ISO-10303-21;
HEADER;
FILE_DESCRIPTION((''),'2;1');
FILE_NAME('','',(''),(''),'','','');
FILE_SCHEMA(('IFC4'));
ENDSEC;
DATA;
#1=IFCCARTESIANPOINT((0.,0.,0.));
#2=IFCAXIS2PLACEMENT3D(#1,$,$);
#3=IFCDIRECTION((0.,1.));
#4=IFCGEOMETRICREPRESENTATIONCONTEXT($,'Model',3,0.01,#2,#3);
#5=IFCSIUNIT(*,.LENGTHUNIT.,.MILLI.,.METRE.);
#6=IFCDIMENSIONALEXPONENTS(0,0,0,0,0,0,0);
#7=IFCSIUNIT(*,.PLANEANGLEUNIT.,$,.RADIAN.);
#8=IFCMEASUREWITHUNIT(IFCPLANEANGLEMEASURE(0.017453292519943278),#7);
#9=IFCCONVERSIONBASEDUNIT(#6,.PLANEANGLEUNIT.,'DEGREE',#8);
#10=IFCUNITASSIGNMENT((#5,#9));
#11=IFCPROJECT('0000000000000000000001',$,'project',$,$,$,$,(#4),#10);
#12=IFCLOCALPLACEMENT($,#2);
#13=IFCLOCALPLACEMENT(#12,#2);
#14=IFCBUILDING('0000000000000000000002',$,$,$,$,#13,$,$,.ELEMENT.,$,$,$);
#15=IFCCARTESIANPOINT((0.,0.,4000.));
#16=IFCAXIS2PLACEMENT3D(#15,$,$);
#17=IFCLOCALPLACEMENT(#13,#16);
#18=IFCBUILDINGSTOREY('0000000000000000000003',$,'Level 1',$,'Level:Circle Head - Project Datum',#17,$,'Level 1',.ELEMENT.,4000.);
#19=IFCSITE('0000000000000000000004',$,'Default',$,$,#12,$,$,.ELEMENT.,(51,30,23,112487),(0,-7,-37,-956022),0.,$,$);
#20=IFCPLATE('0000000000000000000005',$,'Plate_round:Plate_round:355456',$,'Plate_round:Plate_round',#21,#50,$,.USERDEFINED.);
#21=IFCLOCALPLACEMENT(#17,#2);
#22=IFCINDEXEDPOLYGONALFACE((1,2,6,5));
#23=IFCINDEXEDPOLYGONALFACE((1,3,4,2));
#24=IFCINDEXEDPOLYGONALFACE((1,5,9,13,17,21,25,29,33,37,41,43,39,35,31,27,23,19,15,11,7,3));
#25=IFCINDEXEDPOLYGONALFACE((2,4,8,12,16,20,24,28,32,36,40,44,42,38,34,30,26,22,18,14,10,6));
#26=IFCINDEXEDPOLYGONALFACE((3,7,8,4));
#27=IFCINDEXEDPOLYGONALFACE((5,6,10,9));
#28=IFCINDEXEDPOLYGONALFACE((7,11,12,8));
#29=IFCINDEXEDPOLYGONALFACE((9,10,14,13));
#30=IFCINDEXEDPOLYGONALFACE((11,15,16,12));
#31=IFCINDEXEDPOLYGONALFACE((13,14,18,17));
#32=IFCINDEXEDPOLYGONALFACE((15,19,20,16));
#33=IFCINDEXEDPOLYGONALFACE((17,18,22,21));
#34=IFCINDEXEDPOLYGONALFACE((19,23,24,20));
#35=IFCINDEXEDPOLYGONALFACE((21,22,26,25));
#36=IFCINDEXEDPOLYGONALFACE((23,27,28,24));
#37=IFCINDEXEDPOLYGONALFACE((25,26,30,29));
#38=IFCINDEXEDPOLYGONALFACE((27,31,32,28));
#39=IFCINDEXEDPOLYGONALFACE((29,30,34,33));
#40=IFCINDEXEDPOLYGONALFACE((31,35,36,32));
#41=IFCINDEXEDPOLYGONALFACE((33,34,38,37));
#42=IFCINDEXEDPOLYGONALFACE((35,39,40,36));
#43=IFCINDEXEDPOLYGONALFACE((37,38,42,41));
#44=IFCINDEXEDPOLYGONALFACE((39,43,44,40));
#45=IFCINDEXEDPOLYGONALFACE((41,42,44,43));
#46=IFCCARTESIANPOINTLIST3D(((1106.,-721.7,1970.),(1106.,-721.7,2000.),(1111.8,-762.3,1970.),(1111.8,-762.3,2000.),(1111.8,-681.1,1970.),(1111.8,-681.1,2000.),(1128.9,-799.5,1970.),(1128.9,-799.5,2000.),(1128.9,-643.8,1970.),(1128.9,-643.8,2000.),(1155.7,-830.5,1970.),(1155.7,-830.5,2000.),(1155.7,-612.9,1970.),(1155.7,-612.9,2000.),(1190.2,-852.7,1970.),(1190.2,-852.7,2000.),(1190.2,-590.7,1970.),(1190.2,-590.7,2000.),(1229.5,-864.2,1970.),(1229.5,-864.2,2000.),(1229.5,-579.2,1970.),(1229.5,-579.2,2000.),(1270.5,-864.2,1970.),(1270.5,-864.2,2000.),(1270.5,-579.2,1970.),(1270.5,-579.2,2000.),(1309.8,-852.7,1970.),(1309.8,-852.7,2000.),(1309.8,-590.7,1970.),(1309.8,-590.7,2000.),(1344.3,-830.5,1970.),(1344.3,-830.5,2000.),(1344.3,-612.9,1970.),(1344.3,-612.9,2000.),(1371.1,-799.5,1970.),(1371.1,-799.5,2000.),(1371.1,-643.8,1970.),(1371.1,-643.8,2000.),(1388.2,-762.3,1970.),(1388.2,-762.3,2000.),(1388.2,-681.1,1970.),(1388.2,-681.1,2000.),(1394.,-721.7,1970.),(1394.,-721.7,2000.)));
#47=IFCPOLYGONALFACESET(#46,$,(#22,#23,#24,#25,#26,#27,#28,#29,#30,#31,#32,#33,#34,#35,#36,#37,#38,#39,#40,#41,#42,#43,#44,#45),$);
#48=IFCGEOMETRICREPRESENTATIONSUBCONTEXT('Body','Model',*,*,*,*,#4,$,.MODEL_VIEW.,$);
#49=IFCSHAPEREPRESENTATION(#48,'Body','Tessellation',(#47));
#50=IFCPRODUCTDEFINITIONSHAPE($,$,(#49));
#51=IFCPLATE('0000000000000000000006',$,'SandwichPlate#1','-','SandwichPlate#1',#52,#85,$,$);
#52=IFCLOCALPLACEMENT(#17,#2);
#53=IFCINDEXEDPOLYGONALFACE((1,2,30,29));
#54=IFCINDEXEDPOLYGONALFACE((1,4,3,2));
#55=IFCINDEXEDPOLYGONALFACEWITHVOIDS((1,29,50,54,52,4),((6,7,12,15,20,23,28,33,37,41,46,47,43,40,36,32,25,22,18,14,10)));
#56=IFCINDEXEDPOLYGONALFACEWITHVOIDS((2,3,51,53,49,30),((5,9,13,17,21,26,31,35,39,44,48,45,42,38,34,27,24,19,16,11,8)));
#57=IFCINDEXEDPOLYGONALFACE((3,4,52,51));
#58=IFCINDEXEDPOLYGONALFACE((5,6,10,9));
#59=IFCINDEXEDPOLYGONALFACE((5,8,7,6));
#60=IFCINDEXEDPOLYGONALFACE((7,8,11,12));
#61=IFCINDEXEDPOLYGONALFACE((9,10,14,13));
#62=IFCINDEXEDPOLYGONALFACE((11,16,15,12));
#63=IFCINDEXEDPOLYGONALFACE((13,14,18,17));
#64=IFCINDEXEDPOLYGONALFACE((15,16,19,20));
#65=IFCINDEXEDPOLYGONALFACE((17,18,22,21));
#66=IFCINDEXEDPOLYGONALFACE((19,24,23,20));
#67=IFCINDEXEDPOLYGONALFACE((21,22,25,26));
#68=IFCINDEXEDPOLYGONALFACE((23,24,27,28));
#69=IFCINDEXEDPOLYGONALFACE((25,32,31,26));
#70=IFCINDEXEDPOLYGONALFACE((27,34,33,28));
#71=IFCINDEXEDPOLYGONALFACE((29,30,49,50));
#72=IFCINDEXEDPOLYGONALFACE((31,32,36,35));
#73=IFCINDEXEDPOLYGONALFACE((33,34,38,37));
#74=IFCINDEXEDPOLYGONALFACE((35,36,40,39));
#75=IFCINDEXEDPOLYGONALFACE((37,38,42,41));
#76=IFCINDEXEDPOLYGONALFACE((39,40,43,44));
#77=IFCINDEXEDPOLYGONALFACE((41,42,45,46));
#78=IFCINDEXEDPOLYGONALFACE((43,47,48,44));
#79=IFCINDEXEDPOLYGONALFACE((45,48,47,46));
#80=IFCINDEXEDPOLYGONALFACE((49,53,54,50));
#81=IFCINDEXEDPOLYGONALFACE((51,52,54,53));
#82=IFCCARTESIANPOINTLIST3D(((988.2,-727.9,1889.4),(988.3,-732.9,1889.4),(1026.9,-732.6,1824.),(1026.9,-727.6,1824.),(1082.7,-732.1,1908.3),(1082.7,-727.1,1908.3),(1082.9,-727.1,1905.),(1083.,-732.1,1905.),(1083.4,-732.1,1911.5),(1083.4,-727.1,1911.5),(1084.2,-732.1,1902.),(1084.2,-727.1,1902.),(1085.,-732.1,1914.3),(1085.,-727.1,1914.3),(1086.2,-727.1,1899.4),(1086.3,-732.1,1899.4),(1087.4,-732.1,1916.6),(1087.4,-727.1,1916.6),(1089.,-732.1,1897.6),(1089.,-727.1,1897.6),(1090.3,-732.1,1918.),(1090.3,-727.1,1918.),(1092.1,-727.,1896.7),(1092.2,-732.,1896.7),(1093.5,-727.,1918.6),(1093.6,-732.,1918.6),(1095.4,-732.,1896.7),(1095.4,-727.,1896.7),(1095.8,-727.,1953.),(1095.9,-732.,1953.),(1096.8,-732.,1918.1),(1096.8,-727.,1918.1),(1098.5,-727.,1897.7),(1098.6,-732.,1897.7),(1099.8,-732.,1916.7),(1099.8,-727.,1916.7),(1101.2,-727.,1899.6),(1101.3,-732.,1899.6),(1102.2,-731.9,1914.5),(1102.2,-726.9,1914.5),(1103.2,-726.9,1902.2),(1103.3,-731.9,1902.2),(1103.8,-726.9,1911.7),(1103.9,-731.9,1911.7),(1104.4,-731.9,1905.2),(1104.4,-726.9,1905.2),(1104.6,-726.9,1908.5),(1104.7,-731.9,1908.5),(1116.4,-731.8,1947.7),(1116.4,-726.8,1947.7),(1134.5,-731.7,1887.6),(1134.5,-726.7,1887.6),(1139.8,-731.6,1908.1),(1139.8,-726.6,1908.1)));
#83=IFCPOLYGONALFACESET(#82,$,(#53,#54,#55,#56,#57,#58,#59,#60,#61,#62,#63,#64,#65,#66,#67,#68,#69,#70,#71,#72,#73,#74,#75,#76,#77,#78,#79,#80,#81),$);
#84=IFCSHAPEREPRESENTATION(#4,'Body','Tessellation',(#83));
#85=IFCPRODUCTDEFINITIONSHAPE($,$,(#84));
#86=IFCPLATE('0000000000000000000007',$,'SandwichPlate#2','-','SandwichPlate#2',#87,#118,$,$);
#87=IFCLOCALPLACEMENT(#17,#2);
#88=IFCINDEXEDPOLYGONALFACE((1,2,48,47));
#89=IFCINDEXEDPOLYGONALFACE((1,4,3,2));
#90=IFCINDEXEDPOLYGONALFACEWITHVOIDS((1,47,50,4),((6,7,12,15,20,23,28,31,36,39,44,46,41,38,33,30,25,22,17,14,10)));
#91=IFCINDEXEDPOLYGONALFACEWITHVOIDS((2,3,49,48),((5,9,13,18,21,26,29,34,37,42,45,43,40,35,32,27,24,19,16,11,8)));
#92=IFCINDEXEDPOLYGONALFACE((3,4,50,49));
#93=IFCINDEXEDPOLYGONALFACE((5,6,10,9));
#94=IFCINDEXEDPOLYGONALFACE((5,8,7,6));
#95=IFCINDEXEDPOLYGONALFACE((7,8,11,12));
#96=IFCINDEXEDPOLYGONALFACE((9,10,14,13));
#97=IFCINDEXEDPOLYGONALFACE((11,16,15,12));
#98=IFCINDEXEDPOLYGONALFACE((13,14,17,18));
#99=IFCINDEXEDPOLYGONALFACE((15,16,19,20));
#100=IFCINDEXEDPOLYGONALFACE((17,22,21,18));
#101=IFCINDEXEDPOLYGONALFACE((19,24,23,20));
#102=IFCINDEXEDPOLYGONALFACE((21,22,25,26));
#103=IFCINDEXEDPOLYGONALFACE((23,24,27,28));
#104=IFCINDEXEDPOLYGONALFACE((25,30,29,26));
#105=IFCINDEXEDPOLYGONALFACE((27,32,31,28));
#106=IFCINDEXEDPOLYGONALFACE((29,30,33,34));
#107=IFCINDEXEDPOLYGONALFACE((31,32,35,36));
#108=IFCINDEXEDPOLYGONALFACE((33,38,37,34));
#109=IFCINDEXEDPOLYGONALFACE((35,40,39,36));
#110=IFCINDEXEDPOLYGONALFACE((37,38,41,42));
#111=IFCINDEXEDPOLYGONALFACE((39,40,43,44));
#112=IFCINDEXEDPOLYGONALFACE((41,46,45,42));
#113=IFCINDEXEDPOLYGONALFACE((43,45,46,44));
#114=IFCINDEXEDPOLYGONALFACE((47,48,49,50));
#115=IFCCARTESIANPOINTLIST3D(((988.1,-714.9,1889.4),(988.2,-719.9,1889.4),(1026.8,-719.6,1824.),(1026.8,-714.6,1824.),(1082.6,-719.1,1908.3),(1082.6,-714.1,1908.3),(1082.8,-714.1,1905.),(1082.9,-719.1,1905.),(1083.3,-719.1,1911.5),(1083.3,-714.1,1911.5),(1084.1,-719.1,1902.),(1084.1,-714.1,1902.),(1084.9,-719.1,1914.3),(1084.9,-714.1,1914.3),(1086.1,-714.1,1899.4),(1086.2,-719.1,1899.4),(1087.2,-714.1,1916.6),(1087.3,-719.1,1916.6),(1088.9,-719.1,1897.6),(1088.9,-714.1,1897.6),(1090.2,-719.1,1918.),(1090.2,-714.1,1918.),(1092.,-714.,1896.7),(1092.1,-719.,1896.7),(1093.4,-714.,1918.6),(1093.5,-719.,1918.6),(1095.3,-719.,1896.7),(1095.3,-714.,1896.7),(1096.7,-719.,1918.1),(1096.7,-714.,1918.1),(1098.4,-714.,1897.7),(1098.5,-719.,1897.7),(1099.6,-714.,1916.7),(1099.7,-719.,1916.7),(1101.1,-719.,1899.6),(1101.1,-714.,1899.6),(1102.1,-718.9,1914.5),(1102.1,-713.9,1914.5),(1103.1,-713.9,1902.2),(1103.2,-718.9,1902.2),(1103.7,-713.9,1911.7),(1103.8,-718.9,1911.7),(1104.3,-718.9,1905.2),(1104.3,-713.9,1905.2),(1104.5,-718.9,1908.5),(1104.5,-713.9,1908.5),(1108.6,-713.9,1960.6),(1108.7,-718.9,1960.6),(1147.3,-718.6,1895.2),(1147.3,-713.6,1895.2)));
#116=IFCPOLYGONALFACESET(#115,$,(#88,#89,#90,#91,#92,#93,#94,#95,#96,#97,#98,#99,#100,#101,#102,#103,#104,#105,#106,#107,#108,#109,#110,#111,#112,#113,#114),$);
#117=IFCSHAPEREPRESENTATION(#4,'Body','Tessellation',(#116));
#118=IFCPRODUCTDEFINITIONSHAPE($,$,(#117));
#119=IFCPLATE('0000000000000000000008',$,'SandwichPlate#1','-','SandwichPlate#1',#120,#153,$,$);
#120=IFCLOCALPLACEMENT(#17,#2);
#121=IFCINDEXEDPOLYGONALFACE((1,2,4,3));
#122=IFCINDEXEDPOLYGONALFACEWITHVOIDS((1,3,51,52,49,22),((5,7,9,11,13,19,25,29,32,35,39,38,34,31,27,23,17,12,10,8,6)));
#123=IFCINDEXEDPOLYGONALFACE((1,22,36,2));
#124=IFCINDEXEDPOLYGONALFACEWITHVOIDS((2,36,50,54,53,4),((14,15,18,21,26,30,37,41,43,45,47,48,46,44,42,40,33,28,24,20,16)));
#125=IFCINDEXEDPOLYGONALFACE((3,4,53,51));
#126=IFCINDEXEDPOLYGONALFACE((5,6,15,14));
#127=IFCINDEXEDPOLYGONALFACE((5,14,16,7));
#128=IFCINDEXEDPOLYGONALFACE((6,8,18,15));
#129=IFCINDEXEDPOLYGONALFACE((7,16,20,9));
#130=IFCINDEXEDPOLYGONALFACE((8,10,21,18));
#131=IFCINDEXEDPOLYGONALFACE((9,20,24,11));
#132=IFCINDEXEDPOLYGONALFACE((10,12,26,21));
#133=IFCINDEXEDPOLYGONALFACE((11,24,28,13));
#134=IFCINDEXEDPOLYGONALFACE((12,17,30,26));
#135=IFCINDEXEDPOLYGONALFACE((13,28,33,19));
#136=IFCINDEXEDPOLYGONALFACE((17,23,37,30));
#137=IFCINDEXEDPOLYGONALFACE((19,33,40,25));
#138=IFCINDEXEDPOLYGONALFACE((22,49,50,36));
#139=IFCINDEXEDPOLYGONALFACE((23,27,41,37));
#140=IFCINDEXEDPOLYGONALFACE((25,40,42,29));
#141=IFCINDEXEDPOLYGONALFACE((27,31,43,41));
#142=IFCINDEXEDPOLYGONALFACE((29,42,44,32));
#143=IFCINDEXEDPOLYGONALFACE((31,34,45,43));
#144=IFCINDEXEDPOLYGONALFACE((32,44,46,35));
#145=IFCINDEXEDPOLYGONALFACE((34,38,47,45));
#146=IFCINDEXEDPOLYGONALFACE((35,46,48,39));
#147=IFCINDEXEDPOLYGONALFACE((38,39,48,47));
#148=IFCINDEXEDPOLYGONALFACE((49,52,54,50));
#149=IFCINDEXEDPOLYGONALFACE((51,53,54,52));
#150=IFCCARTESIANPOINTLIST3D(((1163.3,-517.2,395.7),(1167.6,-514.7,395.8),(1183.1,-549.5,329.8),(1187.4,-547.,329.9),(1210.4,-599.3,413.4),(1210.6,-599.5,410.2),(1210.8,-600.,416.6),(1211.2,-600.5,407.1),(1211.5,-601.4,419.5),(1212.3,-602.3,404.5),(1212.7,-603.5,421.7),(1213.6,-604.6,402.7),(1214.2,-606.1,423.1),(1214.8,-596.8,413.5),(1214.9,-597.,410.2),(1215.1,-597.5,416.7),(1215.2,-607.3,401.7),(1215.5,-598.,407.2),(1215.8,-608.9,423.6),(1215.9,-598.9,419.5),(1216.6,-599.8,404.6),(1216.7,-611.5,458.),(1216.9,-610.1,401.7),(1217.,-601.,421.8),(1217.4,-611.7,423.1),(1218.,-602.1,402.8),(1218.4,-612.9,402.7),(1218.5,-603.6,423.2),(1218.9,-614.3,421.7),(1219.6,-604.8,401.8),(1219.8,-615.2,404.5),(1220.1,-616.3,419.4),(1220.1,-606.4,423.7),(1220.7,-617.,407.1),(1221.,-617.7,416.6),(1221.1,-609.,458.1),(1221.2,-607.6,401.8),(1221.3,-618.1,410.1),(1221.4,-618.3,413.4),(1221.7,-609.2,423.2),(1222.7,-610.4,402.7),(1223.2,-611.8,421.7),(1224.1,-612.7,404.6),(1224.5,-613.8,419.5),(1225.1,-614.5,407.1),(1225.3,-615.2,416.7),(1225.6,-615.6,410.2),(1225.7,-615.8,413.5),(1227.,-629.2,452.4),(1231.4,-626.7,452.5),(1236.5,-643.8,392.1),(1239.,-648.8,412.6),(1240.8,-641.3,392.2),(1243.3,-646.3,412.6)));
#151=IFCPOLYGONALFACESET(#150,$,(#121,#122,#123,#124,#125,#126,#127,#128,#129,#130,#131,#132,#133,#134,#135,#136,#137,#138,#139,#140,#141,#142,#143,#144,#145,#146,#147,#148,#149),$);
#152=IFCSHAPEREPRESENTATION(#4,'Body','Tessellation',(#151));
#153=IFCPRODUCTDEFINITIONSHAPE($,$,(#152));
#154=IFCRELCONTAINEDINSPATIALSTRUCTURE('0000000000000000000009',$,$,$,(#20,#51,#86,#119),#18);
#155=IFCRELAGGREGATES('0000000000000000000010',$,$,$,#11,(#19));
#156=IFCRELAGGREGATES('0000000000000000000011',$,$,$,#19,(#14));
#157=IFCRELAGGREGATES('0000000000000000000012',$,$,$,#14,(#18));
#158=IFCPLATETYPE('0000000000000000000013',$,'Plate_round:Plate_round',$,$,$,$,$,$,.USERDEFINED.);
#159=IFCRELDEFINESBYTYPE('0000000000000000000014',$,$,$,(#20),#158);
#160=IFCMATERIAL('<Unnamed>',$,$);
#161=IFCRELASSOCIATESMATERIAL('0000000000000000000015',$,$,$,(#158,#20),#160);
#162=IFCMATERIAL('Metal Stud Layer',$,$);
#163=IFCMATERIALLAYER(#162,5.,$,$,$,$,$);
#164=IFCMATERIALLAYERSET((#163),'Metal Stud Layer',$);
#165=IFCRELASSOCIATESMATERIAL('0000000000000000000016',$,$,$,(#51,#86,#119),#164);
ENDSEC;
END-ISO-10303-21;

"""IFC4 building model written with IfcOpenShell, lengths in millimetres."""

from ifc_helpers import new_model, entity, si_unit, converted_unit, direction, frame, origin, origin_with_axes, origin_2d_with_axis, place, context, subcontext, project, spatial, polyline, arc, indexed_curve, circle, outline, extrude, source, transform, mapped, material, layer, layer_set, type_object, type_shapes, element, save


model = new_model("IFC4")

# Units and contexts
model_context = context("Model", 3, precision=0.01, world=origin(), true_north=direction((0.0, 1.0)))
body_context = subcontext(model_context, "Body", "Model", "MODEL_VIEW")
ifc_project = project(units=[si_unit("LENGTHUNIT", "METRE", prefix="MILLI"), converted_unit("PLANEANGLEUNIT", "DEGREE", entity("IfcPlaneAngleMeasure", 0.017453292519943278), si_unit("PLANEANGLEUNIT", "RADIAN"), dimensions=[0, 0, 0, 0, 0, 0, 0])], contexts=[model_context])

# Site, building, storey
site_placement = place(None, origin())
site = spatial("IfcSite", under=ifc_project, at=site_placement, Name="Default", CompositionType="ELEMENT", RefLatitude=(51, 30, 23, 112487), RefLongitude=(0, -7, -37, -956022), RefElevation=0.0)
building_placement = place(site_placement, origin())
building = spatial("IfcBuilding", under=site, at=building_placement, CompositionType="ELEMENT")
storey_placement = place(building_placement, frame((0.0, 0.0, 4000.0)))
storey = spatial("IfcBuildingStorey", under=building, at=storey_placement, Name="Level 1", ObjectType="Level:Circle Head - Project Datum", LongName="Level 1", CompositionType="ELEMENT", Elevation=4000.0)

# Plate
ifc_material_1 = material(Name="<Unnamed>")
plate_type = type_object("IfcPlateType", Name="Plate_round:Plate_round", PredefinedType="USERDEFINED", material=ifc_material_1)
shared_shape = source(origin(), body_context, "Body", "SweptSolid", [
    extrude(outline(indexed_curve([(-144.0, 0.0), (0.0, -144.0), (144.0, 0.0), (0.0, 144.0)], segments=[arc(1, 2, 3), arc(3, 4, 1)], self_intersect=False)), origin(), (0.0, 0.0, 1.0), 30.0),
])
type_shapes(plate_type, [shared_shape])
plate_1_placement = place(storey_placement, frame((1250.0, -721.7, 1970.0)))
element("IfcPlate", 1, at=plate_1_placement, inside=storey, type_object=plate_type, material=ifc_material_1, Name="Plate_round:Plate_round:355456", ObjectType="Plate_round:Plate_round", PredefinedType="USERDEFINED", context=body_context, shape_type="MappedRepresentation", body=[
    mapped(shared_shape, transform((0.0, 0.0, 0.0), scale=1.0)),
])

# Shared definitions
ifc_material_2 = material(Name="Metal Stud Layer")

# Plates, openings
ifc_layer_1 = layer(ifc_material_2, 5.0)
ifc_layer_set_1 = layer_set([ifc_layer_1], Name="Metal Stud Layer")
plate_2_placement = place(storey_placement, frame((1108.8, -731.9, 1960.6), z_axis=(-0.008532, 0.999964, 0.0), x_axis=(0.50884, 0.004342, -0.86085)))
plate_2 = element("IfcPlate", 2, at=plate_2_placement, inside=storey, material=ifc_layer_set_1, Name="SandwichPlate#1", Description="-", ObjectType="SandwichPlate#1", context=model_context, shape_type="SweptSolid", body=[
    extrude(outline(polyline([(15.0, 0.0), (61.0, 0.0), (76.0, 15.0), (76.0, 140.0), (0.0, 140.0), (0.0, 15.0), (15.0, 0.0)])), origin_with_axes(), (0.0, 0.0, 1.0), 5.0),
])
opening_1_placement = place(plate_2_placement, frame((38.0, 40.0, -0.5), z_axis=(0.0, 0.0, 1.0), x_axis=(0.0, 1.0, 0.0)))
element("IfcOpeningElement", 3, at=opening_1_placement, cuts=plate_2, ObjectType="Opening", context=model_context, shape_type="SweptSolid", body=[
    extrude(circle(Radius=11.0, at=origin_2d_with_axis()), origin(), (0.0, 0.0, 1.0), 6.0),
])
plate_3_placement = place(storey_placement, frame((1108.7, -718.9, 1960.6), z_axis=(-0.008532, 0.999964, 0.0), x_axis=(0.50884, 0.004342, -0.86085)))
plate_3 = element("IfcPlate", 4, at=plate_3_placement, inside=storey, material=ifc_layer_set_1, Name="SandwichPlate#2", Description="-", ObjectType="SandwichPlate#2", context=model_context, shape_type="SweptSolid", body=[
    extrude(outline(polyline([(0.0, 0.0), (76.0, 0.0), (76.0, 140.0), (0.0, 140.0), (0.0, 0.0)])), origin_with_axes(), (0.0, 0.0, 1.0), 5.0),
])
opening_2_placement = place(plate_3_placement, frame((38.0, 40.0, -0.5), z_axis=(0.0, 0.0, 1.0), x_axis=(0.0, 1.0, 0.0)))
element("IfcOpeningElement", 5, at=opening_2_placement, cuts=plate_3, ObjectType="Opening", context=model_context, shape_type="SweptSolid", body=[
    extrude(circle(Radius=11.0, at=origin_2d_with_axis()), origin(), (0.0, 0.0, 1.0), 6.0),
])

# Plate, openings
plate_4_placement = place(storey_placement, frame((1247.2, -652.7, 399.6), z_axis=(-0.865935, -0.499948, -0.014432), x_axis=(-0.259821, 0.424992, 0.867107)))
plate_4 = element("IfcPlate", 6, at=plate_4_placement, inside=storey, material=ifc_layer_set_1, Name="SandwichPlate#1", Description="-", ObjectType="SandwichPlate#1", context=model_context, shape_type="SweptSolid", body=[
    extrude(outline(polyline([(0.0, 0.0), (76.0, 0.0), (76.0, 140.0), (0.0, 140.0), (0.0, 0.0)])), origin_with_axes(), (0.0, 0.0, 1.0), 5.0),
])
opening_3_placement = place(plate_4_placement, frame((0.0, 0.0, 0.0), z_axis=(0.0, 0.0, 1.0), x_axis=(1.0, 0.0, 0.0)))
element("IfcOpeningElement", 7, at=opening_3_placement, cuts=plate_4, ObjectType="Opening", context=model_context, shape_type="SweptSolid", body=[
    extrude(outline(polyline([(0.0, 0.0), (15.0, 0.0), (0.0, 15.0), (0.0, 0.0)])), origin(), (0.0, 0.0, 1.0), 5.0),
])
opening_4_placement = place(plate_4_placement, frame((0.0, 0.0, 0.0), z_axis=(0.0, 0.0, 1.0), x_axis=(1.0, 0.0, 0.0)))
element("IfcOpeningElement", 8, at=opening_4_placement, cuts=plate_4, ObjectType="Opening", context=model_context, shape_type="SweptSolid", body=[
    extrude(outline(polyline([(76.0, 0.0), (76.0, 15.0), (61.0, 0.0), (76.0, 0.0)])), origin(), (0.0, 0.0, 1.0), 5.0),
])
opening_5_placement = place(plate_4_placement, frame((38.0, 40.0, -0.5), z_axis=(0.0, 0.0, 1.0), x_axis=(0.0, 1.0, 0.0)))
element("IfcOpeningElement", 9, at=opening_5_placement, cuts=plate_4, ObjectType="Opening", context=model_context, shape_type="SweptSolid", body=[
    extrude(circle(Radius=11.0, at=origin_2d_with_axis()), origin(), (0.0, 0.0, 1.0), 6.0),
])

save(model, "model.ifc")
